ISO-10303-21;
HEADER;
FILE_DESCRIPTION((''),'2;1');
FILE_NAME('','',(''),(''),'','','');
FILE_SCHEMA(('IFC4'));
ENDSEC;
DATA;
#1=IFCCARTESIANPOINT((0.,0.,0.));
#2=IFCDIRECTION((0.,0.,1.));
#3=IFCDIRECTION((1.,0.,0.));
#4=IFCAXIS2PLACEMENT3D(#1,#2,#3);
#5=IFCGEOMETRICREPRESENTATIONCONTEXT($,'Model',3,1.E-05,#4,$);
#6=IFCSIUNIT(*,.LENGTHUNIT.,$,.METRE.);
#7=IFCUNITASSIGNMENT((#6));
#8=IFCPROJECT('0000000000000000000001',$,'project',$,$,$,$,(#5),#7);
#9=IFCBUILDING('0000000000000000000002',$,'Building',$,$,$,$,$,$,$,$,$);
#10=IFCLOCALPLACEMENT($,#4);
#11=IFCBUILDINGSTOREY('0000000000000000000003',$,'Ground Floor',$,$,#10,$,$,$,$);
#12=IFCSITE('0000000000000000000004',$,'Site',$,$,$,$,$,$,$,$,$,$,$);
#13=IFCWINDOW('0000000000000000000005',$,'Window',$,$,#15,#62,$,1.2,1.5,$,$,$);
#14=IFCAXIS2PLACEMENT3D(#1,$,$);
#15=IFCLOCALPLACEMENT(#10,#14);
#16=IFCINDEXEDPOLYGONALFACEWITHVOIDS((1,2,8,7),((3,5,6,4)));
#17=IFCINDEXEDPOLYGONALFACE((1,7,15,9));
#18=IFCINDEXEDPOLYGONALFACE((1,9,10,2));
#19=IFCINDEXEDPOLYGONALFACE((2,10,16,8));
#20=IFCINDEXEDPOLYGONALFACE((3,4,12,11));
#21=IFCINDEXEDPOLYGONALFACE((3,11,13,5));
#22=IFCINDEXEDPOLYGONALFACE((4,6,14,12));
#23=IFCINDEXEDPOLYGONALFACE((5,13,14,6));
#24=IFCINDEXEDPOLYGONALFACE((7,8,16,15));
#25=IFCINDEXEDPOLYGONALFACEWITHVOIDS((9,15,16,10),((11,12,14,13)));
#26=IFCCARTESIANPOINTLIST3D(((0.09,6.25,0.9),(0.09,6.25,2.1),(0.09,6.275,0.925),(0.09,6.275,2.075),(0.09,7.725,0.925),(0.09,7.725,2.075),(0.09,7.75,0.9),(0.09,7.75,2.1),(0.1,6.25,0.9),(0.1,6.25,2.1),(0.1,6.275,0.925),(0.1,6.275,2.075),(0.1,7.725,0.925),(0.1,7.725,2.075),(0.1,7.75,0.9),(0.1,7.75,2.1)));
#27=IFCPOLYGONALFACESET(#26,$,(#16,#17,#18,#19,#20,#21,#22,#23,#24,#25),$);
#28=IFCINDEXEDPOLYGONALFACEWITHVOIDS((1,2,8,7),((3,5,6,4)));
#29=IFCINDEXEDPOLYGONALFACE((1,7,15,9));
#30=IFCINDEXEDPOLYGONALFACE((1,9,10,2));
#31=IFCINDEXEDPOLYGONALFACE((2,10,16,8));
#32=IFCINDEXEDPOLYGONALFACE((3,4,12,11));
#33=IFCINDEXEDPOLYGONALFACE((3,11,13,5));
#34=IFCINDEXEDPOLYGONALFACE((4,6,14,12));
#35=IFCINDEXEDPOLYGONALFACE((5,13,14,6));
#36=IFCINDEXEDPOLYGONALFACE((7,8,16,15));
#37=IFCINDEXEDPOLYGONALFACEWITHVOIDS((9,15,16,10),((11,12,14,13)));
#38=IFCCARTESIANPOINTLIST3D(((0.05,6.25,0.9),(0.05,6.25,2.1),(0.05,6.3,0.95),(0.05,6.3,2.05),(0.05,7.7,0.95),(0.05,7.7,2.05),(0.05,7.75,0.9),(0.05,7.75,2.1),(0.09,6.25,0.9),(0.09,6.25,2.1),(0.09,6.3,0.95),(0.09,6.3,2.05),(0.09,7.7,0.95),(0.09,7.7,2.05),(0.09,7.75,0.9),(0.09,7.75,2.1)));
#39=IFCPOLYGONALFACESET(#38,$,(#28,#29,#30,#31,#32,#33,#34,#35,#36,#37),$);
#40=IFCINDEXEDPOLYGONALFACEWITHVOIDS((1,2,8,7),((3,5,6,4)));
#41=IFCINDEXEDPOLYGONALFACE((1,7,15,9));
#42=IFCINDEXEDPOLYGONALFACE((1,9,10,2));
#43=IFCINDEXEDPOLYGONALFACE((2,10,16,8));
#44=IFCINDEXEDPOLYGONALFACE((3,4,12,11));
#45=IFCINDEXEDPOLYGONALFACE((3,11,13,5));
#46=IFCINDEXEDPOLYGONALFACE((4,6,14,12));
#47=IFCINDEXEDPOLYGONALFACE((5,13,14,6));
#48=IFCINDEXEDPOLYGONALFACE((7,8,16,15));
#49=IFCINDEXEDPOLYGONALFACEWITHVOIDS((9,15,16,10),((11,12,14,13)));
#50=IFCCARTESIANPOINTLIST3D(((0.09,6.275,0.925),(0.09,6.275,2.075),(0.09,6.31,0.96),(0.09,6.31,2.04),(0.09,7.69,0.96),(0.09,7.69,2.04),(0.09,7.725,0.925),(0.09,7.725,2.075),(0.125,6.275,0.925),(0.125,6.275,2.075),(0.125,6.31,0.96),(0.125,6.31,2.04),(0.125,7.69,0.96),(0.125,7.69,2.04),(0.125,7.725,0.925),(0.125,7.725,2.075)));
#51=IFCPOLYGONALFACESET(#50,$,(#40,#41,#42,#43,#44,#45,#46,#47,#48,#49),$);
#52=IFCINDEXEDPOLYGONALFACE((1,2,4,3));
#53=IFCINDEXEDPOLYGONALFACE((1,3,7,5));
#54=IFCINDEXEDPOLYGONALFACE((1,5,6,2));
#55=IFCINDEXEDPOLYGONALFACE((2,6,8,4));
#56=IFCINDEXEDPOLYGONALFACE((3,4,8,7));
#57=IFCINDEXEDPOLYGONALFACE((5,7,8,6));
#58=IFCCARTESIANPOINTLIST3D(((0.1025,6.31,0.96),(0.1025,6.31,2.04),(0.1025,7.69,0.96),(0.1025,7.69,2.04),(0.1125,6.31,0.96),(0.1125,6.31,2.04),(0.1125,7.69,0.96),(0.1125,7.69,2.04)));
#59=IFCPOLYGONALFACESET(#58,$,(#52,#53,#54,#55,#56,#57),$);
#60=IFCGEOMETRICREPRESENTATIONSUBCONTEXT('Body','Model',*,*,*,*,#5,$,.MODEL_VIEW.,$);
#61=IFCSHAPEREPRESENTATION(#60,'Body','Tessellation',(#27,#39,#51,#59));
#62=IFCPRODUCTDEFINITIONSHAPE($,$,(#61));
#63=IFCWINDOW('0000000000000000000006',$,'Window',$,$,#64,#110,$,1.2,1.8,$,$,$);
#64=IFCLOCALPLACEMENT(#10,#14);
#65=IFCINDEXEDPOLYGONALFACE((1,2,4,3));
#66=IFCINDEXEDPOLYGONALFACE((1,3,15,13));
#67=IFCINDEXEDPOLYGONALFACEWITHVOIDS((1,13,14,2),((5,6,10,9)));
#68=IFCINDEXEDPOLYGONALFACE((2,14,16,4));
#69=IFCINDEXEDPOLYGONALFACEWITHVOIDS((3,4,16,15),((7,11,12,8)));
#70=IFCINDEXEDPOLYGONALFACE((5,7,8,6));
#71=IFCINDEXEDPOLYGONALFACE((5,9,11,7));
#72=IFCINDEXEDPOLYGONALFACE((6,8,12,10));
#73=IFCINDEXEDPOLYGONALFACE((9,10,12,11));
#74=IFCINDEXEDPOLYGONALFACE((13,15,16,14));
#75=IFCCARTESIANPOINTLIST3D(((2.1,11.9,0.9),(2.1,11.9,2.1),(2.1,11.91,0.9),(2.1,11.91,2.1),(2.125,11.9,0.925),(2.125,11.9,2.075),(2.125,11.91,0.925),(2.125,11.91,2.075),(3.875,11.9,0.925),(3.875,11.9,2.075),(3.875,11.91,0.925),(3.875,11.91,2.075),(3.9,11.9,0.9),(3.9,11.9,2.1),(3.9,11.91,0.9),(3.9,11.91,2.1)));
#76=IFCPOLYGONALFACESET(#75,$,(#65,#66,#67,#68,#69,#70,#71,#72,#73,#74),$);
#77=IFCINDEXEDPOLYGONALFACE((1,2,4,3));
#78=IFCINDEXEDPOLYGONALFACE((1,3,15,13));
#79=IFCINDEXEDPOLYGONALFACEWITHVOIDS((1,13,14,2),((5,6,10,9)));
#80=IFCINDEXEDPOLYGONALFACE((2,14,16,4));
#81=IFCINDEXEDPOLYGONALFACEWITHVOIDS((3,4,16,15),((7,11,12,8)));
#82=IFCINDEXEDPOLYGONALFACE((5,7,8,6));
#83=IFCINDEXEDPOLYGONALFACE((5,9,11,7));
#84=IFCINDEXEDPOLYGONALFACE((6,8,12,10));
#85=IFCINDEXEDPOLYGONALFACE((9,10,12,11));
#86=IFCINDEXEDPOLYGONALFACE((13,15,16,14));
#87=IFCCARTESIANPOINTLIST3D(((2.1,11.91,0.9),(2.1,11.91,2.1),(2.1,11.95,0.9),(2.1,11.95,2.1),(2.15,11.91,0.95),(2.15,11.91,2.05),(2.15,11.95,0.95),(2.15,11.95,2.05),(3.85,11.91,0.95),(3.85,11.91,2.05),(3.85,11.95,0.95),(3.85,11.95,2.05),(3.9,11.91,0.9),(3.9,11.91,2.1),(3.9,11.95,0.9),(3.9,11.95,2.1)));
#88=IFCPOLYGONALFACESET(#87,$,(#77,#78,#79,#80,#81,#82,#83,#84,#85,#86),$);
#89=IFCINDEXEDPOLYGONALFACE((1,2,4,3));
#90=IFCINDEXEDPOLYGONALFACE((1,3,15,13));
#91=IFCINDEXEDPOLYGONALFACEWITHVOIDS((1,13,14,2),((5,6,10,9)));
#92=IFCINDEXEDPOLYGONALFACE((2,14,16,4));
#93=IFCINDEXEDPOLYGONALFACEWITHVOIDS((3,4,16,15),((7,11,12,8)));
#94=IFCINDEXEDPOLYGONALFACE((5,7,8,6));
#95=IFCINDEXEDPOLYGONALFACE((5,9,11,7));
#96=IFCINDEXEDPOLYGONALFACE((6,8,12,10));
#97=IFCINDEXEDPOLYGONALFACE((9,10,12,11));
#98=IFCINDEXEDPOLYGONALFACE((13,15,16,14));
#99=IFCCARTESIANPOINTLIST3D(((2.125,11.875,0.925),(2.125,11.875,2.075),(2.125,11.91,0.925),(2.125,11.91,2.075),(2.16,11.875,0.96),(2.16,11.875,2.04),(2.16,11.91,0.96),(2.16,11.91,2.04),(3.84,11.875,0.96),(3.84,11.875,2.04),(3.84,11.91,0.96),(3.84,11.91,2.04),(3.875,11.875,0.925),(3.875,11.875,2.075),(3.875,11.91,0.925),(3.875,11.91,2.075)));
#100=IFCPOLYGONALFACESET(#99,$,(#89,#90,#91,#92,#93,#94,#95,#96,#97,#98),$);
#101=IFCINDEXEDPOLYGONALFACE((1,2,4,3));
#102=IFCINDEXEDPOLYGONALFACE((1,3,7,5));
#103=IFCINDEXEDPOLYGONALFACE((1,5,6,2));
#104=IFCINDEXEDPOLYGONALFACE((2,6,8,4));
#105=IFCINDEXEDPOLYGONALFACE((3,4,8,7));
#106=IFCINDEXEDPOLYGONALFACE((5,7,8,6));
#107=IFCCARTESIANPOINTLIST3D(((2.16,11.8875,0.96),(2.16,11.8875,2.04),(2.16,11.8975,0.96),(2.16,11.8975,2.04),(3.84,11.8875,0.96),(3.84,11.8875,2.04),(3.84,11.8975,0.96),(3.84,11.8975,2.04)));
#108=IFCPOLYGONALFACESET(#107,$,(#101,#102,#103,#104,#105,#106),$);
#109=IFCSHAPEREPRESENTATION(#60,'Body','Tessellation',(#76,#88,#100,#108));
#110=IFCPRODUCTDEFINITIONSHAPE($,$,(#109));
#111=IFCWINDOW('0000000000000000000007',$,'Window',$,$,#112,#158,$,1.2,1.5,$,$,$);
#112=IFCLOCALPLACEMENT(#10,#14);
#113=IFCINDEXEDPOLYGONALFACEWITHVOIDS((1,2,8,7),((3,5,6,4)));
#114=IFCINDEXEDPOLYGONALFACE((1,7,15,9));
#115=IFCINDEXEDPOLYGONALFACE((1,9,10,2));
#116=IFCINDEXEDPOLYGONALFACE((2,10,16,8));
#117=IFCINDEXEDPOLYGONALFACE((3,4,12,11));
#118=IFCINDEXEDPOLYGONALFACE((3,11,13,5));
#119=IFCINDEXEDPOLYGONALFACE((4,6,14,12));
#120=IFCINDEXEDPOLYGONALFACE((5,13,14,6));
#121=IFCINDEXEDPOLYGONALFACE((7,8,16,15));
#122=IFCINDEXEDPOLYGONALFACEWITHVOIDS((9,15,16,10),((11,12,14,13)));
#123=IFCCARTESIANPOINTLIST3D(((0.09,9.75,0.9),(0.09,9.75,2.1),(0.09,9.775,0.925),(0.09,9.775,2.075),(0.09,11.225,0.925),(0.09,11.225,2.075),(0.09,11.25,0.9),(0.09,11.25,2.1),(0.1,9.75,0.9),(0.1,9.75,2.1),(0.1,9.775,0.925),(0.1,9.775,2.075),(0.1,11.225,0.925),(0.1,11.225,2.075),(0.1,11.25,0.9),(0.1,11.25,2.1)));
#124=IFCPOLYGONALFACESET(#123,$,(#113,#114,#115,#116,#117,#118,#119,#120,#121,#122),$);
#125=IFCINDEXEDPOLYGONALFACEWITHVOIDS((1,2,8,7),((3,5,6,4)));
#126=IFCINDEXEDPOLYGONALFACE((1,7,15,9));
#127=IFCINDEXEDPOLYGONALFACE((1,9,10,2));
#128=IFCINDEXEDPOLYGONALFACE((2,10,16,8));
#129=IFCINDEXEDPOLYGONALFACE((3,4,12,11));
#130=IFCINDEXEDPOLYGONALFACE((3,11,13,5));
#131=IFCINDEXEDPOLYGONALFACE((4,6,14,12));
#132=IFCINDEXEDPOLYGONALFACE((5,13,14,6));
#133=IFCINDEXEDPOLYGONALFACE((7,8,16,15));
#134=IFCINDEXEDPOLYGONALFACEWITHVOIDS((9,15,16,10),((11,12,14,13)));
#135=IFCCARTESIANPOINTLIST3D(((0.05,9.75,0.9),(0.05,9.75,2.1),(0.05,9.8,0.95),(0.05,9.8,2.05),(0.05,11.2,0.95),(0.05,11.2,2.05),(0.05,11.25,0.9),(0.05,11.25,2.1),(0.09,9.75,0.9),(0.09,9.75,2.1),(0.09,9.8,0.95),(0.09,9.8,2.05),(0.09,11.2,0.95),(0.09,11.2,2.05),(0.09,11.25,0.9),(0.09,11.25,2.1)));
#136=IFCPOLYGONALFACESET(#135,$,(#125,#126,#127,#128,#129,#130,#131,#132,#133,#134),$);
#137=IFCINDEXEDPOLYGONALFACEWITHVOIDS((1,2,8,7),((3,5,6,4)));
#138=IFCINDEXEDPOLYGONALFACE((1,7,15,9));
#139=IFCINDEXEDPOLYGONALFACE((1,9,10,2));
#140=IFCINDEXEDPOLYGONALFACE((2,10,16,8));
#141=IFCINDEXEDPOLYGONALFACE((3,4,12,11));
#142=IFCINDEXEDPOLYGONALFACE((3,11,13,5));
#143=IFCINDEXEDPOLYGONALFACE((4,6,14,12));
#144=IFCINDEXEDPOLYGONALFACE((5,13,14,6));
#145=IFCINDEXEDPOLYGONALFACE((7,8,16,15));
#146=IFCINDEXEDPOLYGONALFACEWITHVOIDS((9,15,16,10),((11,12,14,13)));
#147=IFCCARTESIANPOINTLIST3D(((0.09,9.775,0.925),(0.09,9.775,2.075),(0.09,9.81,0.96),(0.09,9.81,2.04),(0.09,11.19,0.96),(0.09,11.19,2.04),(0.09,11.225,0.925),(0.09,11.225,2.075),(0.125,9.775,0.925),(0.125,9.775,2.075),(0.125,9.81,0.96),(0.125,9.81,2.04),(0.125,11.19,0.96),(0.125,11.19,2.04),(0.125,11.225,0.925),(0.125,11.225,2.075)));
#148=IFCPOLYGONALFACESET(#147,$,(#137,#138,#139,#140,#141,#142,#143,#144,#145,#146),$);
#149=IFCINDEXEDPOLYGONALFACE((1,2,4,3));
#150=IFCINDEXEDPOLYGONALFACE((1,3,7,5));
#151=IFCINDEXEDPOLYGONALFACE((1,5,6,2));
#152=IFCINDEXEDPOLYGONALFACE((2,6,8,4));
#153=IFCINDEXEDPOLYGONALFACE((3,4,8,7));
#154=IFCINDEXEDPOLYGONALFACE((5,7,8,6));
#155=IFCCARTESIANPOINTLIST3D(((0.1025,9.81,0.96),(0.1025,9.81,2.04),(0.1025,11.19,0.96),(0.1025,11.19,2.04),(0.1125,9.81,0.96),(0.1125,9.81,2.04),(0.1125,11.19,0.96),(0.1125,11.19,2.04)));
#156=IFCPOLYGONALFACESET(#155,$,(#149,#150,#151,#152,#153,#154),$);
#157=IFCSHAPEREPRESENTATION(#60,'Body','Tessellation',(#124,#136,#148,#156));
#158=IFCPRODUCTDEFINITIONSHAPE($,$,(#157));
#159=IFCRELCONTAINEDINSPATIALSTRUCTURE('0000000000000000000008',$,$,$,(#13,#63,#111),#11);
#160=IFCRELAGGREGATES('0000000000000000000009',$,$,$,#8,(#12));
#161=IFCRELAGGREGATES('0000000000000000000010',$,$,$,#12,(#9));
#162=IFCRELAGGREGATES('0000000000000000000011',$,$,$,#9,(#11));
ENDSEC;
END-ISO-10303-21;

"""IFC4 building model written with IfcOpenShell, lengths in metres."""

from ifc_helpers import new_model, si_unit, frame, origin_with_axes, place, context, subcontext, project, spatial, line, indexed_curve, outline, extrude, element, save


model = new_model("IFC4")

# Units and contexts
model_context = context("Model", 3, precision=1e-05, world=origin_with_axes())
body_context = subcontext(model_context, "Body", "Model", "MODEL_VIEW")
ifc_project = project(units=[si_unit("LENGTHUNIT", "METRE")], contexts=[model_context])

# Site, building, storey
site = spatial("IfcSite", under=ifc_project, Name="Site")
building = spatial("IfcBuilding", under=site, Name="Building")
storey_placement = place(None, origin_with_axes())
storey = spatial("IfcBuildingStorey", under=building, at=storey_placement, Name="Ground Floor")

# Windows
window_1_placement = place(storey_placement, frame((0.0, 7.75, 0.9), z_axis=(0.0, 0.0, 1.0), x_axis=(0.0, -1.0, 0.0)))
element("IfcWindow", 1, at=window_1_placement, inside=storey, Name="Window", OverallHeight=1.2, OverallWidth=1.5, context=body_context, shape_type="SweptSolid", body=[
    extrude(outline(indexed_curve([(0.0, 0.0), (1.5, 0.0), (1.5, 1.2), (0.0, 1.2)], segments=[line(1, 2, 3, 4, 1)]), holes=[indexed_curve([(0.025, 0.025), (1.475, 0.025), (1.475, 1.175), (0.025, 1.175)], segments=[line(1, 2, 3, 4, 1)])]), frame((0.0, 0.09, 0.0), z_axis=(0.0, -1.0, 0.0), x_axis=(1.0, 0.0, 0.0)), (0.0, 0.0, -1.0), 0.01),
    extrude(outline(indexed_curve([(0.0, 0.0), (1.5, 0.0), (1.5, 1.2), (0.0, 1.2)], segments=[line(1, 2, 3, 4, 1)]), holes=[indexed_curve([(0.05, 0.05), (1.45, 0.05), (1.45, 1.15), (0.05, 1.15)], segments=[line(1, 2, 3, 4, 1)])]), frame((0.0, 0.05, 0.0), z_axis=(0.0, -1.0, 0.0), x_axis=(1.0, 0.0, 0.0)), (0.0, 0.0, -1.0), 0.04),
    extrude(outline(indexed_curve([(0.0, 0.0), (1.45, 0.0), (1.45, 1.15), (0.0, 1.15)], segments=[line(1, 2, 3, 4, 1)]), holes=[indexed_curve([(0.035, 0.035), (1.415, 0.035), (1.415, 1.115), (0.035, 1.115)], segments=[line(1, 2, 3, 4, 1)])]), frame((0.025, 0.09, 0.025), z_axis=(0.0, -1.0, 0.0), x_axis=(1.0, 0.0, 0.0)), (0.0, 0.0, -1.0), 0.035),
    extrude(outline(indexed_curve([(0.035, 0.035), (1.415, 0.035), (1.415, 1.115), (0.035, 1.115)], segments=[line(1, 2, 3, 4, 1)])), frame((0.025, 0.1025, 0.025), z_axis=(0.0, -1.0, 0.0), x_axis=(1.0, 0.0, 0.0)), (0.0, 0.0, -1.0), 0.01),
])
window_2_placement = place(storey_placement, frame((3.9, 12.0, 0.9), z_axis=(0.0, 0.0, 1.0), x_axis=(-1.0, 0.0, 0.0)))
element("IfcWindow", 2, at=window_2_placement, inside=storey, Name="Window", OverallHeight=1.2, OverallWidth=1.8, context=body_context, shape_type="SweptSolid", body=[
    extrude(outline(indexed_curve([(0.0, 0.0), (1.8, 0.0), (1.8, 1.2), (0.0, 1.2)], segments=[line(1, 2, 3, 4, 1)]), holes=[indexed_curve([(0.025, 0.025), (1.775, 0.025), (1.775, 1.175), (0.025, 1.175)], segments=[line(1, 2, 3, 4, 1)])]), frame((0.0, 0.09, 0.0), z_axis=(0.0, -1.0, 0.0), x_axis=(1.0, 0.0, 0.0)), (0.0, 0.0, -1.0), 0.01),
    extrude(outline(indexed_curve([(0.0, 0.0), (1.8, 0.0), (1.8, 1.2), (0.0, 1.2)], segments=[line(1, 2, 3, 4, 1)]), holes=[indexed_curve([(0.05, 0.05), (1.75, 0.05), (1.75, 1.15), (0.05, 1.15)], segments=[line(1, 2, 3, 4, 1)])]), frame((0.0, 0.05, 0.0), z_axis=(0.0, -1.0, 0.0), x_axis=(1.0, 0.0, 0.0)), (0.0, 0.0, -1.0), 0.04),
    extrude(outline(indexed_curve([(0.0, 0.0), (1.75, 0.0), (1.75, 1.15), (0.0, 1.15)], segments=[line(1, 2, 3, 4, 1)]), holes=[indexed_curve([(0.035, 0.035), (1.715, 0.035), (1.715, 1.115), (0.035, 1.115)], segments=[line(1, 2, 3, 4, 1)])]), frame((0.025, 0.09, 0.025), z_axis=(0.0, -1.0, 0.0), x_axis=(1.0, 0.0, 0.0)), (0.0, 0.0, -1.0), 0.035),
    extrude(outline(indexed_curve([(0.035, 0.035), (1.715, 0.035), (1.715, 1.115), (0.035, 1.115)], segments=[line(1, 2, 3, 4, 1)])), frame((0.025, 0.1025, 0.025), z_axis=(0.0, -1.0, 0.0), x_axis=(1.0, 0.0, 0.0)), (0.0, 0.0, -1.0), 0.01),
])
window_3_placement = place(storey_placement, frame((0.0, 11.25, 0.9), z_axis=(0.0, 0.0, 1.0), x_axis=(0.0, -1.0, 0.0)))
element("IfcWindow", 3, at=window_3_placement, inside=storey, Name="Window", OverallHeight=1.2, OverallWidth=1.5, context=body_context, shape_type="SweptSolid", body=[
    extrude(outline(indexed_curve([(0.0, 0.0), (1.5, 0.0), (1.5, 1.2), (0.0, 1.2)], segments=[line(1, 2, 3, 4, 1)]), holes=[indexed_curve([(0.025, 0.025), (1.475, 0.025), (1.475, 1.175), (0.025, 1.175)], segments=[line(1, 2, 3, 4, 1)])]), frame((0.0, 0.09, 0.0), z_axis=(0.0, -1.0, 0.0), x_axis=(1.0, 0.0, 0.0)), (0.0, 0.0, -1.0), 0.01),
    extrude(outline(indexed_curve([(0.0, 0.0), (1.5, 0.0), (1.5, 1.2), (0.0, 1.2)], segments=[line(1, 2, 3, 4, 1)]), holes=[indexed_curve([(0.05, 0.05), (1.45, 0.05), (1.45, 1.15), (0.05, 1.15)], segments=[line(1, 2, 3, 4, 1)])]), frame((0.0, 0.05, 0.0), z_axis=(0.0, -1.0, 0.0), x_axis=(1.0, 0.0, 0.0)), (0.0, 0.0, -1.0), 0.04),
    extrude(outline(indexed_curve([(0.0, 0.0), (1.45, 0.0), (1.45, 1.15), (0.0, 1.15)], segments=[line(1, 2, 3, 4, 1)]), holes=[indexed_curve([(0.035, 0.035), (1.415, 0.035), (1.415, 1.115), (0.035, 1.115)], segments=[line(1, 2, 3, 4, 1)])]), frame((0.025, 0.09, 0.025), z_axis=(0.0, -1.0, 0.0), x_axis=(1.0, 0.0, 0.0)), (0.0, 0.0, -1.0), 0.035),
    extrude(outline(indexed_curve([(0.035, 0.035), (1.415, 0.035), (1.415, 1.115), (0.035, 1.115)], segments=[line(1, 2, 3, 4, 1)])), frame((0.025, 0.1025, 0.025), z_axis=(0.0, -1.0, 0.0), x_axis=(1.0, 0.0, 0.0)), (0.0, 0.0, -1.0), 0.01),
])

save(model, "model.ifc")
